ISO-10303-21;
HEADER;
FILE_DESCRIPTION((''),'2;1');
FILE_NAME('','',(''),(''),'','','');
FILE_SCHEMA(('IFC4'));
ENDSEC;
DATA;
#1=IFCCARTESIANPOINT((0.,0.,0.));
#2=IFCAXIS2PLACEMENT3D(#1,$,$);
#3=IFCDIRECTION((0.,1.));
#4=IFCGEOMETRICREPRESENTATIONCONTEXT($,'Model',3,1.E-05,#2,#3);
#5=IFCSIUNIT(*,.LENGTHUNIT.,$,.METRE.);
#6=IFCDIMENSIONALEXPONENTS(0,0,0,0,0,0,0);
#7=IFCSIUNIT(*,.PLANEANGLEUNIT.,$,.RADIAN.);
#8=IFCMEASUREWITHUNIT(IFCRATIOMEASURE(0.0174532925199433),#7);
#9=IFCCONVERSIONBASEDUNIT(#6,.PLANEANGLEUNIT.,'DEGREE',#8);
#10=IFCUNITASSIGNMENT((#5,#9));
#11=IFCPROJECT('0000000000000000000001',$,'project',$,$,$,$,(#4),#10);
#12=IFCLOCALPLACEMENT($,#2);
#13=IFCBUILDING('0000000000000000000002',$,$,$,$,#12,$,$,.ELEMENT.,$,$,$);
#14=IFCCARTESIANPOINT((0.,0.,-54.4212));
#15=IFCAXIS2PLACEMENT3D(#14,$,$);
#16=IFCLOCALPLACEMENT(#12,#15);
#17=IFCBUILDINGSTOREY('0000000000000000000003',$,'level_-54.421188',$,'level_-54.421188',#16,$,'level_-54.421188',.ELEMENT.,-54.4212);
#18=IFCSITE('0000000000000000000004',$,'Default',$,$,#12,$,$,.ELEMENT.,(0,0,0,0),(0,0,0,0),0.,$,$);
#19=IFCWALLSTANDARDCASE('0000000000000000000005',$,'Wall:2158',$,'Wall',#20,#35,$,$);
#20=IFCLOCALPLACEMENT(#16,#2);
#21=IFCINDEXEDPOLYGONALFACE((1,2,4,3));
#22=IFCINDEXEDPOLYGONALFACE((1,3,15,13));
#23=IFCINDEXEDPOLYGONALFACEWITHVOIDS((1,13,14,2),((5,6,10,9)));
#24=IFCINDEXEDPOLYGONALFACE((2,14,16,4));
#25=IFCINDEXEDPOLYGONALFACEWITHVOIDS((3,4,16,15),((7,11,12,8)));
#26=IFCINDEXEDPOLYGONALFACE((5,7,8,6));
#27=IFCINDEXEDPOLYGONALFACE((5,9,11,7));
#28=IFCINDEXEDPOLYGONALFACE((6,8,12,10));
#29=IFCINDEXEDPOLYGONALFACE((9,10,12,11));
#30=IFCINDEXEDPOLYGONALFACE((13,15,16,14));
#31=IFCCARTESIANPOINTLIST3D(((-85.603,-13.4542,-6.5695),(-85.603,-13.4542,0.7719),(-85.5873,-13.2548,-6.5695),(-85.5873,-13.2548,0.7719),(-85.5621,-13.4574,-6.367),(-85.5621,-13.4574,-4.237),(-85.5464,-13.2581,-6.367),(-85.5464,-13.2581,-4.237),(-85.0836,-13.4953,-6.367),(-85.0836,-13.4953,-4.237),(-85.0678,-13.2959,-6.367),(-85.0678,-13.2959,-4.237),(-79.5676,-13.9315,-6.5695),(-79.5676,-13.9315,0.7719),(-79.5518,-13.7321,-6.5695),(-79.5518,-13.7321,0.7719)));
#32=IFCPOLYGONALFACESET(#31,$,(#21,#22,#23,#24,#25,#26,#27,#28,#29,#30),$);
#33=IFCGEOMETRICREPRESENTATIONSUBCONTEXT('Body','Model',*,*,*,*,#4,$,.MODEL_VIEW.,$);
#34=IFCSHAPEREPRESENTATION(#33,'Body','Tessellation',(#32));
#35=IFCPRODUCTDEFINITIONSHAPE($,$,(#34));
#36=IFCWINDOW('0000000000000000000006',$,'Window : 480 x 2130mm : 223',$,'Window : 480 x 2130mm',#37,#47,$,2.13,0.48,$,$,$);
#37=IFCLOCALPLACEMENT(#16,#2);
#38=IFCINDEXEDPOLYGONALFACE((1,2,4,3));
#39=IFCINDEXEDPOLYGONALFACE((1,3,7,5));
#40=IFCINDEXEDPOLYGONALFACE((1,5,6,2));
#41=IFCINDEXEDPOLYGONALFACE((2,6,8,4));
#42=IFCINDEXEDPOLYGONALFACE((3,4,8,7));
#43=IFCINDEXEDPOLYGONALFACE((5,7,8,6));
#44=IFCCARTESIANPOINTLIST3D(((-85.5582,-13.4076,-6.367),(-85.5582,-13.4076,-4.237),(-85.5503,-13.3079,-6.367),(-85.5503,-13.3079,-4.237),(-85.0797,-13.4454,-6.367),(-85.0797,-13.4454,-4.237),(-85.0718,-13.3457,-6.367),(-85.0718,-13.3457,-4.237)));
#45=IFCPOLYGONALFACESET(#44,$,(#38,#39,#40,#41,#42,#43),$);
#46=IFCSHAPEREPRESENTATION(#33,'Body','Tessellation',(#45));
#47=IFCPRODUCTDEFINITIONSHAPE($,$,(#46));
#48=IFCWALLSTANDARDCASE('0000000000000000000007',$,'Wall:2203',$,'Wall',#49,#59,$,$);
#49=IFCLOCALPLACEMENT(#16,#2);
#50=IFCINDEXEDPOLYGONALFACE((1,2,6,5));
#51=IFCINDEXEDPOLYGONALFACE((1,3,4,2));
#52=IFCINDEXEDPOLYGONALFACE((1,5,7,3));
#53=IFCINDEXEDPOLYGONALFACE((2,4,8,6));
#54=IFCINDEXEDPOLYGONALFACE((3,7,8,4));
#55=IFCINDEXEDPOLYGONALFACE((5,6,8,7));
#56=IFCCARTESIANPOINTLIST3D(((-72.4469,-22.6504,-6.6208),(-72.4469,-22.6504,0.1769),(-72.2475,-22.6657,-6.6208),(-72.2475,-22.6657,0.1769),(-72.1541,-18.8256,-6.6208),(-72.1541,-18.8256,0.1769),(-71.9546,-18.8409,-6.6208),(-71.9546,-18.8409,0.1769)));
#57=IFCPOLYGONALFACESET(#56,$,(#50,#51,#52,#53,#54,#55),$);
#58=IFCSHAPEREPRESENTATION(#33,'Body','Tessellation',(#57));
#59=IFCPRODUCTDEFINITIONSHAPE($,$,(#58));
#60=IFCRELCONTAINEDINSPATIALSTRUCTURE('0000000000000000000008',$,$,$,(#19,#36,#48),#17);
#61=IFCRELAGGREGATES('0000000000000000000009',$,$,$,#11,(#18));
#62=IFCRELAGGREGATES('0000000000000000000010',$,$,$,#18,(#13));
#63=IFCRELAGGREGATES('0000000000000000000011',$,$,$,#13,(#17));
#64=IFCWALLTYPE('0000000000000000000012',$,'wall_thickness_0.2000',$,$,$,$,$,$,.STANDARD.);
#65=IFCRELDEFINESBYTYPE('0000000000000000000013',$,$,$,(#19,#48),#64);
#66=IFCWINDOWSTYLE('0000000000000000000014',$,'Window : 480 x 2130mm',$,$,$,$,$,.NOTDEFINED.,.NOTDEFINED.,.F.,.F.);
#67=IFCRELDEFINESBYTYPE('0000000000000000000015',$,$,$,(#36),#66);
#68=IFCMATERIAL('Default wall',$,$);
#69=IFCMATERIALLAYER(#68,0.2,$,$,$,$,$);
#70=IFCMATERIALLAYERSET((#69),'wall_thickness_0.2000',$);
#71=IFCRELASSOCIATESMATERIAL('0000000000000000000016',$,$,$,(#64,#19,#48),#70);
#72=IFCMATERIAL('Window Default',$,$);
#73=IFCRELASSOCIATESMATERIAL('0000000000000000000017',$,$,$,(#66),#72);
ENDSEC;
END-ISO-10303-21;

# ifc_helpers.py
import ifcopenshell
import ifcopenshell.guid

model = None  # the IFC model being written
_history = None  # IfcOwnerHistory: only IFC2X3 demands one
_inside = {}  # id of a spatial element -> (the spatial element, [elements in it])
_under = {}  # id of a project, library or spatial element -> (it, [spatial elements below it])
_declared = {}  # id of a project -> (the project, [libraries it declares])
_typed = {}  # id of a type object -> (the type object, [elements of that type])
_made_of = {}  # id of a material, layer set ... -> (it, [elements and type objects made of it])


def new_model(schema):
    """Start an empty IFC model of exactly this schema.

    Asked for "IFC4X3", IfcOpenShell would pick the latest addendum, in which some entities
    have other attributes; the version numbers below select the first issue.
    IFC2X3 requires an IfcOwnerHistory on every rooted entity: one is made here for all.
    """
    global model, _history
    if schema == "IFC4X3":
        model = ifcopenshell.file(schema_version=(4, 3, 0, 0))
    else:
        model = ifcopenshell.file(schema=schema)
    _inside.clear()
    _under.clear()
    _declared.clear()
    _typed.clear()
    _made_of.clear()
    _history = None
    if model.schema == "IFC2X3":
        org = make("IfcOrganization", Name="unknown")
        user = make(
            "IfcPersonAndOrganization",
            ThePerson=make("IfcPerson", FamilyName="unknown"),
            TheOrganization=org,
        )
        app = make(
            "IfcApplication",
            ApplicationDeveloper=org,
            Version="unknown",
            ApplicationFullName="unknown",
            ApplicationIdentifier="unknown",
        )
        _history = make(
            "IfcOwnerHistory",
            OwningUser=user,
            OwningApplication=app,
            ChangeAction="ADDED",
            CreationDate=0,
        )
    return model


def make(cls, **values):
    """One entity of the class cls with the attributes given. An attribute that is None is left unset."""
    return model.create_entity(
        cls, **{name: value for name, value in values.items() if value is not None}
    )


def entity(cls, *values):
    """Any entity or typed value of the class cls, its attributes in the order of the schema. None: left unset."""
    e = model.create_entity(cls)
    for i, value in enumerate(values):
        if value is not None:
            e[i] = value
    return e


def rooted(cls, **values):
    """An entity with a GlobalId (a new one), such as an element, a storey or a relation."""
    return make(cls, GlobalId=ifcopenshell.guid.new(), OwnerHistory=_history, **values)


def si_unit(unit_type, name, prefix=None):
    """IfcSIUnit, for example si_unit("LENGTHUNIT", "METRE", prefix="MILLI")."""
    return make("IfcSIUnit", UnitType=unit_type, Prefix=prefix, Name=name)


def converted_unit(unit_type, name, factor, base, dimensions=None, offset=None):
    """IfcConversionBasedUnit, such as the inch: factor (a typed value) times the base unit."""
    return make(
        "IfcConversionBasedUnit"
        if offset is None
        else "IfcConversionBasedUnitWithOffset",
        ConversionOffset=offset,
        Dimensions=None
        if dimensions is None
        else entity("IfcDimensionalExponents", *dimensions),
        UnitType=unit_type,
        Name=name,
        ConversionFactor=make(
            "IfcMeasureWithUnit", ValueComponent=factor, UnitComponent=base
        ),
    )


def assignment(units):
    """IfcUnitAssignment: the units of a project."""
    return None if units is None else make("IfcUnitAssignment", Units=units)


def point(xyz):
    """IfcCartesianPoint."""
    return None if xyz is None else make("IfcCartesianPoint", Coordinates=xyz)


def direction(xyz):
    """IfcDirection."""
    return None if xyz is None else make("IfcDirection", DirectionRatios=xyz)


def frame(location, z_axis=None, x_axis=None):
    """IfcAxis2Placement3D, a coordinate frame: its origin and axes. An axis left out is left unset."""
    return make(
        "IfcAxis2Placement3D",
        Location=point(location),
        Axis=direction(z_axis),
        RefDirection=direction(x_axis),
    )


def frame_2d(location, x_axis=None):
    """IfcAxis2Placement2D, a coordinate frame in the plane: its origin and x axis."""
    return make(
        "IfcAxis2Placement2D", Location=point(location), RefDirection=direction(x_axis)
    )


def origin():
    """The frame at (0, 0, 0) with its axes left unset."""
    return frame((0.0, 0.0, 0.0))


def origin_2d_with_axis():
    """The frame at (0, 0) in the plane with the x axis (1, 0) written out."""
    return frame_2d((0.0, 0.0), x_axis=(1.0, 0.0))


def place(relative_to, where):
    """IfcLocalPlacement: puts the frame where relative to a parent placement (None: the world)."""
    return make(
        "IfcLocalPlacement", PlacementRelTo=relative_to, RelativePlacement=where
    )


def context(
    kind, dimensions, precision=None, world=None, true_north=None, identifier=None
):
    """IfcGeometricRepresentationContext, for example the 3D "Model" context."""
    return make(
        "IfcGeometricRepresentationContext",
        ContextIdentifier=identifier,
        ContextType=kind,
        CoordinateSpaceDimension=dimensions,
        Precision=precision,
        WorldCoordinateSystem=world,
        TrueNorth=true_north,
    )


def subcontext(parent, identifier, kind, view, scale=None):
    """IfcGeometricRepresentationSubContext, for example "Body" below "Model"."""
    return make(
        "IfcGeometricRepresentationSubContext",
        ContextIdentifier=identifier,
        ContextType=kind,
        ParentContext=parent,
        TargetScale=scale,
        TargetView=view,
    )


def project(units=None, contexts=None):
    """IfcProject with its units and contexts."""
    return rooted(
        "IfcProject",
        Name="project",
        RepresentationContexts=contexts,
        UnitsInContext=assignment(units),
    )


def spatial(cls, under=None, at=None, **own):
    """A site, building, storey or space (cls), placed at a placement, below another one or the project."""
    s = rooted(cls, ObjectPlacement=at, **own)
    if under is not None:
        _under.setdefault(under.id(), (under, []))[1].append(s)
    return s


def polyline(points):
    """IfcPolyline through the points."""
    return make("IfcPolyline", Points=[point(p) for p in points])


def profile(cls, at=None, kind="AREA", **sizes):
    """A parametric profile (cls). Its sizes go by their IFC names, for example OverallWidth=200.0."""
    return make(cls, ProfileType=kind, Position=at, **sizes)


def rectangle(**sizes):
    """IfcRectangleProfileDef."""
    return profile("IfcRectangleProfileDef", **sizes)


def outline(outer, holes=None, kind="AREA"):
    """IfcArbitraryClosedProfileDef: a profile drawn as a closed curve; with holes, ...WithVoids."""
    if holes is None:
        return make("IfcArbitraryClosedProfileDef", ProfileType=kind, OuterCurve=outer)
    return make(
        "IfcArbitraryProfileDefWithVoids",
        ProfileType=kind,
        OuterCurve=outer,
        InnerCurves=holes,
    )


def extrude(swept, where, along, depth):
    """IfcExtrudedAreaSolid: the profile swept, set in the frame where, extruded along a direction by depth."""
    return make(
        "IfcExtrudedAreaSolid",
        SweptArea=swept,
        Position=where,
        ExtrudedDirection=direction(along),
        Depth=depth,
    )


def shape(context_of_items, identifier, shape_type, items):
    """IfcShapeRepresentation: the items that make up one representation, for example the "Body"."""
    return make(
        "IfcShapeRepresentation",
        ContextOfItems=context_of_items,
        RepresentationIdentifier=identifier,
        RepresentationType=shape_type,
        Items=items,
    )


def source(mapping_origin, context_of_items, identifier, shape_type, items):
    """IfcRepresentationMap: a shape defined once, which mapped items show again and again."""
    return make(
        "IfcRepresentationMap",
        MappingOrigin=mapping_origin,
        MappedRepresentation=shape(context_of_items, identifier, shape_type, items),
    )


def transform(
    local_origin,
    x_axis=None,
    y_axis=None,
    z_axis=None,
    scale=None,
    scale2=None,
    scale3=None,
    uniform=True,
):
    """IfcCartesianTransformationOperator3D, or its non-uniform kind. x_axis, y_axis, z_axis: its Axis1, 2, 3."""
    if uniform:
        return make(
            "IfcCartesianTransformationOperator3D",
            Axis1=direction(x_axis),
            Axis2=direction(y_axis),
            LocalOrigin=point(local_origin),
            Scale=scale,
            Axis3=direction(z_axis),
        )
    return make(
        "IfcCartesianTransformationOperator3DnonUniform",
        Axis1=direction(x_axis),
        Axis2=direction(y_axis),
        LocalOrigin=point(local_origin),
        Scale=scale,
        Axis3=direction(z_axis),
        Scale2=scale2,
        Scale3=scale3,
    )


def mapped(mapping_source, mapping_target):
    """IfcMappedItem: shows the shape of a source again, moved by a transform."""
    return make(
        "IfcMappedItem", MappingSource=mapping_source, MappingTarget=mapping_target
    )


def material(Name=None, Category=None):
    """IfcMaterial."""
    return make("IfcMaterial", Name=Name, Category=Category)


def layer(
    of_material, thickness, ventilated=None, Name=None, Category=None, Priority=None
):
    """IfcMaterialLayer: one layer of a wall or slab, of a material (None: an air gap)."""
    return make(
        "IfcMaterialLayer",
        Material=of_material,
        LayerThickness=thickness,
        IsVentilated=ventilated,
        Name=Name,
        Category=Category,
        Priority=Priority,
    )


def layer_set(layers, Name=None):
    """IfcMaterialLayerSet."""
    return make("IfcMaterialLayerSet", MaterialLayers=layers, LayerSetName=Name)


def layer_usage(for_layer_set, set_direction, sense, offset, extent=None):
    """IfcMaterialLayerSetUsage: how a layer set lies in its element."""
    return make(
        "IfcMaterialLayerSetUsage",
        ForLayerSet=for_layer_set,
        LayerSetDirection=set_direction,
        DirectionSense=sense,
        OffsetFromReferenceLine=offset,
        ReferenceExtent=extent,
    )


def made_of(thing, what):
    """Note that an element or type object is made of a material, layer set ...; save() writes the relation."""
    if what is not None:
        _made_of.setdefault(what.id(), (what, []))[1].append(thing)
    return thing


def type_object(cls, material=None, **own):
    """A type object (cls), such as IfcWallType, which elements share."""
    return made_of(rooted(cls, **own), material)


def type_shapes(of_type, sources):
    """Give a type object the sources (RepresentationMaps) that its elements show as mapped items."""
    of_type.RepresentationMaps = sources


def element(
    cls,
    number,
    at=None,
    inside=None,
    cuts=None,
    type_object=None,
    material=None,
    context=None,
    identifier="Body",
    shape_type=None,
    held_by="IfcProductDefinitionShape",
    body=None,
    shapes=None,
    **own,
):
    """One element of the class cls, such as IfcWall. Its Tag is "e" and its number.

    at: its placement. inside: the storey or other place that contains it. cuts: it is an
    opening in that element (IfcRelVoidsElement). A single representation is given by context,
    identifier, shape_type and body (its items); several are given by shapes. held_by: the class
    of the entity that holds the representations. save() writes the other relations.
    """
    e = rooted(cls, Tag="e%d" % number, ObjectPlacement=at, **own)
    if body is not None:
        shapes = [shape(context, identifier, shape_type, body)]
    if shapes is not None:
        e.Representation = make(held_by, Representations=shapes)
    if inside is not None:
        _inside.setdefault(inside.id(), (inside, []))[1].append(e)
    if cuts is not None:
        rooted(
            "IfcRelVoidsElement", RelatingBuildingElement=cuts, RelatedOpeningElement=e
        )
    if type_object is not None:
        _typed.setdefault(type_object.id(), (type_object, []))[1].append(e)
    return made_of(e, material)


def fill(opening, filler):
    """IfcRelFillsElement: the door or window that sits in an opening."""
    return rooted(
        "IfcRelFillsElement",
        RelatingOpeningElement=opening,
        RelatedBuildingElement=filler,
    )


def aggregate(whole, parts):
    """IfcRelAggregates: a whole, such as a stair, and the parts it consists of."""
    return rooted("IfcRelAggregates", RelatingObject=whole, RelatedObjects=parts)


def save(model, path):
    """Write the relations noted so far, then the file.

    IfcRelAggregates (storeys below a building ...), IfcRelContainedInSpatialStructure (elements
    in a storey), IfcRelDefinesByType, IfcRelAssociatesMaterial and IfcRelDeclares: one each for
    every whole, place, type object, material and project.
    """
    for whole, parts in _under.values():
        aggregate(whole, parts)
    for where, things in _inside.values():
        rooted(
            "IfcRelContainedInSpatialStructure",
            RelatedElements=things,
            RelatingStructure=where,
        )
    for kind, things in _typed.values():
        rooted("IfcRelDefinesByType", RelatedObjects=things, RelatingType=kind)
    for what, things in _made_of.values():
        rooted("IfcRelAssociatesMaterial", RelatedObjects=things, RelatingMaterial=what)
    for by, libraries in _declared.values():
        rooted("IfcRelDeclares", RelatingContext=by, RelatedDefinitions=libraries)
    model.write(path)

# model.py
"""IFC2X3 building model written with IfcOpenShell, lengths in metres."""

from ifc_helpers import new_model, entity, si_unit, converted_unit, direction, frame, frame_2d, origin, origin_2d_with_axis, place, context, subcontext, project, spatial, polyline, rectangle, outline, extrude, source, transform, mapped, material, layer, layer_set, layer_usage, type_object, type_shapes, element, fill, save


model = new_model("IFC2X3")

# Units and contexts
model_context = context("Model", 3, precision=1e-05, world=origin(), true_north=direction((0.0, 1.0)))
body_context = subcontext(model_context, "Body", "Model", "MODEL_VIEW")
ifc_project = project(units=[si_unit("LENGTHUNIT", "METRE"), converted_unit("PLANEANGLEUNIT", "DEGREE", entity("IfcRatioMeasure", 0.0174532925199433), si_unit("PLANEANGLEUNIT", "RADIAN"), dimensions=[0, 0, 0, 0, 0, 0, 0])], contexts=[model_context])

# Site, building, storey
placement_1 = place(None, origin())
site = spatial("IfcSite", under=ifc_project, at=placement_1, Name="Default", CompositionType="ELEMENT", RefLatitude=(0, 0, 0, 0), RefLongitude=(0, 0, 0, 0), RefElevation=0.0)
building = spatial("IfcBuilding", under=site, at=placement_1, CompositionType="ELEMENT")
storey_placement = place(placement_1, frame((0.0, 0.0, -54.4212)))
storey = spatial("IfcBuildingStorey", under=building, at=storey_placement, Name="level_-54.421188", ObjectType="level_-54.421188", LongName="level_-54.421188", CompositionType="ELEMENT", Elevation=-54.4212)

# Shared definitions
ifc_material_1 = material(Name="Default wall")
ifc_layer = layer(ifc_material_1, 0.2)
ifc_layer_set = layer_set([ifc_layer], Name="wall_thickness_0.2000")
ifc_layer_usage = layer_usage(ifc_layer_set, "AXIS2", "POSITIVE", -0.1)
wall_type = type_object("IfcWallType", Name="wall_thickness_0.2000", PredefinedType="STANDARD", material=ifc_layer_set)

# Shared definitions
ifc_material_2 = material(Name="Window Default")

# Wall, opening, window
placement_2 = place(placement_1, frame((0.0, 0.0, -60.9907)))
wall_1_placement = place(placement_2, frame((-79.5597, -13.8318, 0.0), z_axis=(0.0, 0.0, 1.0), x_axis=(-0.996888, 0.07883, 0.0)))
wall_1 = element("IfcWallStandardCase", 1, at=wall_1_placement, inside=storey, type_object=wall_type, material=ifc_layer_usage, Name="Wall:2158", ObjectType="Wall", context=body_context, shape_type="SweptSolid", body=[
    extrude(outline(polyline([(6.0543, -0.1), (6.0543, 0.1), (0.0, 0.1), (0.0, -0.1), (6.0543, -0.1)])), origin(), (0.0, 0.0, 1.0), 7.3414),
])
opening_1_placement = place(wall_1_placement, frame((5.5332, -0.1, 0.2025)))
opening_1 = element("IfcOpeningElement", 2, at=opening_1_placement, cuts=wall_1, ObjectType="Opening", context=body_context, shape_type="SweptSolid", body=[
    extrude(rectangle(XDim=0.48, YDim=2.13, at=frame_2d((1.065, 0.24), x_axis=(0.0, 1.0))), frame((0.0, 0.0, 0.0), z_axis=(0.0, 1.0, 0.0), x_axis=(0.0, 0.0, 1.0)), (0.0, 0.0, 1.0), 0.2),
])
window_style_1 = type_object("IfcWindowStyle", Name="Window : 480 x 2130mm", ConstructionType="NOTDEFINED", OperationType="NOTDEFINED", ParameterTakesPrecedence=False, Sizeable=False, material=ifc_material_2)
shared_shape_1 = source(origin(), body_context, "Body", "SweptSolid", [
    extrude(rectangle(XDim=0.1, YDim=0.48, at=origin_2d_with_axis()), frame((0.24, 0.1, 0.0), z_axis=(0.0, 0.0, 1.0), x_axis=(0.0, 1.0, 0.0)), (0.0, 0.0, 1.0), 2.13),
])
type_shapes(window_style_1, [shared_shape_1])
window_1_placement = place(opening_1_placement, origin())
window_1 = element("IfcWindow", 3, at=window_1_placement, inside=storey, type_object=window_style_1, Name="Window : 480 x 2130mm : 223", ObjectType="Window : 480 x 2130mm", OverallHeight=2.13, OverallWidth=0.48, context=body_context, shape_type="MappedRepresentation", body=[
    mapped(shared_shape_1, transform((0.0, 0.0, 0.0), scale=1.0)),
])
fill(opening_1, window_1)

# Wall
placement_3 = place(placement_1, frame((0.0, 0.0, -61.042)))
wall_2_placement = place(placement_3, frame((-72.0543, -18.8333, 0.0), z_axis=(0.0, 0.0, 1.0), x_axis=(-0.07634, -0.997082, 0.0)))
element("IfcWallStandardCase", 4, at=wall_2_placement, inside=storey, type_object=wall_type, material=ifc_layer_usage, Name="Wall:2203", ObjectType="Wall", context=body_context, shape_type="SweptSolid", body=[
    extrude(outline(polyline([(3.836, -0.1), (3.836, 0.1), (0.0, 0.1), (0.0, -0.1), (3.836, -0.1)])), origin(), (0.0, 0.0, 1.0), 6.7978),
])

save(model, "model.ifc")
